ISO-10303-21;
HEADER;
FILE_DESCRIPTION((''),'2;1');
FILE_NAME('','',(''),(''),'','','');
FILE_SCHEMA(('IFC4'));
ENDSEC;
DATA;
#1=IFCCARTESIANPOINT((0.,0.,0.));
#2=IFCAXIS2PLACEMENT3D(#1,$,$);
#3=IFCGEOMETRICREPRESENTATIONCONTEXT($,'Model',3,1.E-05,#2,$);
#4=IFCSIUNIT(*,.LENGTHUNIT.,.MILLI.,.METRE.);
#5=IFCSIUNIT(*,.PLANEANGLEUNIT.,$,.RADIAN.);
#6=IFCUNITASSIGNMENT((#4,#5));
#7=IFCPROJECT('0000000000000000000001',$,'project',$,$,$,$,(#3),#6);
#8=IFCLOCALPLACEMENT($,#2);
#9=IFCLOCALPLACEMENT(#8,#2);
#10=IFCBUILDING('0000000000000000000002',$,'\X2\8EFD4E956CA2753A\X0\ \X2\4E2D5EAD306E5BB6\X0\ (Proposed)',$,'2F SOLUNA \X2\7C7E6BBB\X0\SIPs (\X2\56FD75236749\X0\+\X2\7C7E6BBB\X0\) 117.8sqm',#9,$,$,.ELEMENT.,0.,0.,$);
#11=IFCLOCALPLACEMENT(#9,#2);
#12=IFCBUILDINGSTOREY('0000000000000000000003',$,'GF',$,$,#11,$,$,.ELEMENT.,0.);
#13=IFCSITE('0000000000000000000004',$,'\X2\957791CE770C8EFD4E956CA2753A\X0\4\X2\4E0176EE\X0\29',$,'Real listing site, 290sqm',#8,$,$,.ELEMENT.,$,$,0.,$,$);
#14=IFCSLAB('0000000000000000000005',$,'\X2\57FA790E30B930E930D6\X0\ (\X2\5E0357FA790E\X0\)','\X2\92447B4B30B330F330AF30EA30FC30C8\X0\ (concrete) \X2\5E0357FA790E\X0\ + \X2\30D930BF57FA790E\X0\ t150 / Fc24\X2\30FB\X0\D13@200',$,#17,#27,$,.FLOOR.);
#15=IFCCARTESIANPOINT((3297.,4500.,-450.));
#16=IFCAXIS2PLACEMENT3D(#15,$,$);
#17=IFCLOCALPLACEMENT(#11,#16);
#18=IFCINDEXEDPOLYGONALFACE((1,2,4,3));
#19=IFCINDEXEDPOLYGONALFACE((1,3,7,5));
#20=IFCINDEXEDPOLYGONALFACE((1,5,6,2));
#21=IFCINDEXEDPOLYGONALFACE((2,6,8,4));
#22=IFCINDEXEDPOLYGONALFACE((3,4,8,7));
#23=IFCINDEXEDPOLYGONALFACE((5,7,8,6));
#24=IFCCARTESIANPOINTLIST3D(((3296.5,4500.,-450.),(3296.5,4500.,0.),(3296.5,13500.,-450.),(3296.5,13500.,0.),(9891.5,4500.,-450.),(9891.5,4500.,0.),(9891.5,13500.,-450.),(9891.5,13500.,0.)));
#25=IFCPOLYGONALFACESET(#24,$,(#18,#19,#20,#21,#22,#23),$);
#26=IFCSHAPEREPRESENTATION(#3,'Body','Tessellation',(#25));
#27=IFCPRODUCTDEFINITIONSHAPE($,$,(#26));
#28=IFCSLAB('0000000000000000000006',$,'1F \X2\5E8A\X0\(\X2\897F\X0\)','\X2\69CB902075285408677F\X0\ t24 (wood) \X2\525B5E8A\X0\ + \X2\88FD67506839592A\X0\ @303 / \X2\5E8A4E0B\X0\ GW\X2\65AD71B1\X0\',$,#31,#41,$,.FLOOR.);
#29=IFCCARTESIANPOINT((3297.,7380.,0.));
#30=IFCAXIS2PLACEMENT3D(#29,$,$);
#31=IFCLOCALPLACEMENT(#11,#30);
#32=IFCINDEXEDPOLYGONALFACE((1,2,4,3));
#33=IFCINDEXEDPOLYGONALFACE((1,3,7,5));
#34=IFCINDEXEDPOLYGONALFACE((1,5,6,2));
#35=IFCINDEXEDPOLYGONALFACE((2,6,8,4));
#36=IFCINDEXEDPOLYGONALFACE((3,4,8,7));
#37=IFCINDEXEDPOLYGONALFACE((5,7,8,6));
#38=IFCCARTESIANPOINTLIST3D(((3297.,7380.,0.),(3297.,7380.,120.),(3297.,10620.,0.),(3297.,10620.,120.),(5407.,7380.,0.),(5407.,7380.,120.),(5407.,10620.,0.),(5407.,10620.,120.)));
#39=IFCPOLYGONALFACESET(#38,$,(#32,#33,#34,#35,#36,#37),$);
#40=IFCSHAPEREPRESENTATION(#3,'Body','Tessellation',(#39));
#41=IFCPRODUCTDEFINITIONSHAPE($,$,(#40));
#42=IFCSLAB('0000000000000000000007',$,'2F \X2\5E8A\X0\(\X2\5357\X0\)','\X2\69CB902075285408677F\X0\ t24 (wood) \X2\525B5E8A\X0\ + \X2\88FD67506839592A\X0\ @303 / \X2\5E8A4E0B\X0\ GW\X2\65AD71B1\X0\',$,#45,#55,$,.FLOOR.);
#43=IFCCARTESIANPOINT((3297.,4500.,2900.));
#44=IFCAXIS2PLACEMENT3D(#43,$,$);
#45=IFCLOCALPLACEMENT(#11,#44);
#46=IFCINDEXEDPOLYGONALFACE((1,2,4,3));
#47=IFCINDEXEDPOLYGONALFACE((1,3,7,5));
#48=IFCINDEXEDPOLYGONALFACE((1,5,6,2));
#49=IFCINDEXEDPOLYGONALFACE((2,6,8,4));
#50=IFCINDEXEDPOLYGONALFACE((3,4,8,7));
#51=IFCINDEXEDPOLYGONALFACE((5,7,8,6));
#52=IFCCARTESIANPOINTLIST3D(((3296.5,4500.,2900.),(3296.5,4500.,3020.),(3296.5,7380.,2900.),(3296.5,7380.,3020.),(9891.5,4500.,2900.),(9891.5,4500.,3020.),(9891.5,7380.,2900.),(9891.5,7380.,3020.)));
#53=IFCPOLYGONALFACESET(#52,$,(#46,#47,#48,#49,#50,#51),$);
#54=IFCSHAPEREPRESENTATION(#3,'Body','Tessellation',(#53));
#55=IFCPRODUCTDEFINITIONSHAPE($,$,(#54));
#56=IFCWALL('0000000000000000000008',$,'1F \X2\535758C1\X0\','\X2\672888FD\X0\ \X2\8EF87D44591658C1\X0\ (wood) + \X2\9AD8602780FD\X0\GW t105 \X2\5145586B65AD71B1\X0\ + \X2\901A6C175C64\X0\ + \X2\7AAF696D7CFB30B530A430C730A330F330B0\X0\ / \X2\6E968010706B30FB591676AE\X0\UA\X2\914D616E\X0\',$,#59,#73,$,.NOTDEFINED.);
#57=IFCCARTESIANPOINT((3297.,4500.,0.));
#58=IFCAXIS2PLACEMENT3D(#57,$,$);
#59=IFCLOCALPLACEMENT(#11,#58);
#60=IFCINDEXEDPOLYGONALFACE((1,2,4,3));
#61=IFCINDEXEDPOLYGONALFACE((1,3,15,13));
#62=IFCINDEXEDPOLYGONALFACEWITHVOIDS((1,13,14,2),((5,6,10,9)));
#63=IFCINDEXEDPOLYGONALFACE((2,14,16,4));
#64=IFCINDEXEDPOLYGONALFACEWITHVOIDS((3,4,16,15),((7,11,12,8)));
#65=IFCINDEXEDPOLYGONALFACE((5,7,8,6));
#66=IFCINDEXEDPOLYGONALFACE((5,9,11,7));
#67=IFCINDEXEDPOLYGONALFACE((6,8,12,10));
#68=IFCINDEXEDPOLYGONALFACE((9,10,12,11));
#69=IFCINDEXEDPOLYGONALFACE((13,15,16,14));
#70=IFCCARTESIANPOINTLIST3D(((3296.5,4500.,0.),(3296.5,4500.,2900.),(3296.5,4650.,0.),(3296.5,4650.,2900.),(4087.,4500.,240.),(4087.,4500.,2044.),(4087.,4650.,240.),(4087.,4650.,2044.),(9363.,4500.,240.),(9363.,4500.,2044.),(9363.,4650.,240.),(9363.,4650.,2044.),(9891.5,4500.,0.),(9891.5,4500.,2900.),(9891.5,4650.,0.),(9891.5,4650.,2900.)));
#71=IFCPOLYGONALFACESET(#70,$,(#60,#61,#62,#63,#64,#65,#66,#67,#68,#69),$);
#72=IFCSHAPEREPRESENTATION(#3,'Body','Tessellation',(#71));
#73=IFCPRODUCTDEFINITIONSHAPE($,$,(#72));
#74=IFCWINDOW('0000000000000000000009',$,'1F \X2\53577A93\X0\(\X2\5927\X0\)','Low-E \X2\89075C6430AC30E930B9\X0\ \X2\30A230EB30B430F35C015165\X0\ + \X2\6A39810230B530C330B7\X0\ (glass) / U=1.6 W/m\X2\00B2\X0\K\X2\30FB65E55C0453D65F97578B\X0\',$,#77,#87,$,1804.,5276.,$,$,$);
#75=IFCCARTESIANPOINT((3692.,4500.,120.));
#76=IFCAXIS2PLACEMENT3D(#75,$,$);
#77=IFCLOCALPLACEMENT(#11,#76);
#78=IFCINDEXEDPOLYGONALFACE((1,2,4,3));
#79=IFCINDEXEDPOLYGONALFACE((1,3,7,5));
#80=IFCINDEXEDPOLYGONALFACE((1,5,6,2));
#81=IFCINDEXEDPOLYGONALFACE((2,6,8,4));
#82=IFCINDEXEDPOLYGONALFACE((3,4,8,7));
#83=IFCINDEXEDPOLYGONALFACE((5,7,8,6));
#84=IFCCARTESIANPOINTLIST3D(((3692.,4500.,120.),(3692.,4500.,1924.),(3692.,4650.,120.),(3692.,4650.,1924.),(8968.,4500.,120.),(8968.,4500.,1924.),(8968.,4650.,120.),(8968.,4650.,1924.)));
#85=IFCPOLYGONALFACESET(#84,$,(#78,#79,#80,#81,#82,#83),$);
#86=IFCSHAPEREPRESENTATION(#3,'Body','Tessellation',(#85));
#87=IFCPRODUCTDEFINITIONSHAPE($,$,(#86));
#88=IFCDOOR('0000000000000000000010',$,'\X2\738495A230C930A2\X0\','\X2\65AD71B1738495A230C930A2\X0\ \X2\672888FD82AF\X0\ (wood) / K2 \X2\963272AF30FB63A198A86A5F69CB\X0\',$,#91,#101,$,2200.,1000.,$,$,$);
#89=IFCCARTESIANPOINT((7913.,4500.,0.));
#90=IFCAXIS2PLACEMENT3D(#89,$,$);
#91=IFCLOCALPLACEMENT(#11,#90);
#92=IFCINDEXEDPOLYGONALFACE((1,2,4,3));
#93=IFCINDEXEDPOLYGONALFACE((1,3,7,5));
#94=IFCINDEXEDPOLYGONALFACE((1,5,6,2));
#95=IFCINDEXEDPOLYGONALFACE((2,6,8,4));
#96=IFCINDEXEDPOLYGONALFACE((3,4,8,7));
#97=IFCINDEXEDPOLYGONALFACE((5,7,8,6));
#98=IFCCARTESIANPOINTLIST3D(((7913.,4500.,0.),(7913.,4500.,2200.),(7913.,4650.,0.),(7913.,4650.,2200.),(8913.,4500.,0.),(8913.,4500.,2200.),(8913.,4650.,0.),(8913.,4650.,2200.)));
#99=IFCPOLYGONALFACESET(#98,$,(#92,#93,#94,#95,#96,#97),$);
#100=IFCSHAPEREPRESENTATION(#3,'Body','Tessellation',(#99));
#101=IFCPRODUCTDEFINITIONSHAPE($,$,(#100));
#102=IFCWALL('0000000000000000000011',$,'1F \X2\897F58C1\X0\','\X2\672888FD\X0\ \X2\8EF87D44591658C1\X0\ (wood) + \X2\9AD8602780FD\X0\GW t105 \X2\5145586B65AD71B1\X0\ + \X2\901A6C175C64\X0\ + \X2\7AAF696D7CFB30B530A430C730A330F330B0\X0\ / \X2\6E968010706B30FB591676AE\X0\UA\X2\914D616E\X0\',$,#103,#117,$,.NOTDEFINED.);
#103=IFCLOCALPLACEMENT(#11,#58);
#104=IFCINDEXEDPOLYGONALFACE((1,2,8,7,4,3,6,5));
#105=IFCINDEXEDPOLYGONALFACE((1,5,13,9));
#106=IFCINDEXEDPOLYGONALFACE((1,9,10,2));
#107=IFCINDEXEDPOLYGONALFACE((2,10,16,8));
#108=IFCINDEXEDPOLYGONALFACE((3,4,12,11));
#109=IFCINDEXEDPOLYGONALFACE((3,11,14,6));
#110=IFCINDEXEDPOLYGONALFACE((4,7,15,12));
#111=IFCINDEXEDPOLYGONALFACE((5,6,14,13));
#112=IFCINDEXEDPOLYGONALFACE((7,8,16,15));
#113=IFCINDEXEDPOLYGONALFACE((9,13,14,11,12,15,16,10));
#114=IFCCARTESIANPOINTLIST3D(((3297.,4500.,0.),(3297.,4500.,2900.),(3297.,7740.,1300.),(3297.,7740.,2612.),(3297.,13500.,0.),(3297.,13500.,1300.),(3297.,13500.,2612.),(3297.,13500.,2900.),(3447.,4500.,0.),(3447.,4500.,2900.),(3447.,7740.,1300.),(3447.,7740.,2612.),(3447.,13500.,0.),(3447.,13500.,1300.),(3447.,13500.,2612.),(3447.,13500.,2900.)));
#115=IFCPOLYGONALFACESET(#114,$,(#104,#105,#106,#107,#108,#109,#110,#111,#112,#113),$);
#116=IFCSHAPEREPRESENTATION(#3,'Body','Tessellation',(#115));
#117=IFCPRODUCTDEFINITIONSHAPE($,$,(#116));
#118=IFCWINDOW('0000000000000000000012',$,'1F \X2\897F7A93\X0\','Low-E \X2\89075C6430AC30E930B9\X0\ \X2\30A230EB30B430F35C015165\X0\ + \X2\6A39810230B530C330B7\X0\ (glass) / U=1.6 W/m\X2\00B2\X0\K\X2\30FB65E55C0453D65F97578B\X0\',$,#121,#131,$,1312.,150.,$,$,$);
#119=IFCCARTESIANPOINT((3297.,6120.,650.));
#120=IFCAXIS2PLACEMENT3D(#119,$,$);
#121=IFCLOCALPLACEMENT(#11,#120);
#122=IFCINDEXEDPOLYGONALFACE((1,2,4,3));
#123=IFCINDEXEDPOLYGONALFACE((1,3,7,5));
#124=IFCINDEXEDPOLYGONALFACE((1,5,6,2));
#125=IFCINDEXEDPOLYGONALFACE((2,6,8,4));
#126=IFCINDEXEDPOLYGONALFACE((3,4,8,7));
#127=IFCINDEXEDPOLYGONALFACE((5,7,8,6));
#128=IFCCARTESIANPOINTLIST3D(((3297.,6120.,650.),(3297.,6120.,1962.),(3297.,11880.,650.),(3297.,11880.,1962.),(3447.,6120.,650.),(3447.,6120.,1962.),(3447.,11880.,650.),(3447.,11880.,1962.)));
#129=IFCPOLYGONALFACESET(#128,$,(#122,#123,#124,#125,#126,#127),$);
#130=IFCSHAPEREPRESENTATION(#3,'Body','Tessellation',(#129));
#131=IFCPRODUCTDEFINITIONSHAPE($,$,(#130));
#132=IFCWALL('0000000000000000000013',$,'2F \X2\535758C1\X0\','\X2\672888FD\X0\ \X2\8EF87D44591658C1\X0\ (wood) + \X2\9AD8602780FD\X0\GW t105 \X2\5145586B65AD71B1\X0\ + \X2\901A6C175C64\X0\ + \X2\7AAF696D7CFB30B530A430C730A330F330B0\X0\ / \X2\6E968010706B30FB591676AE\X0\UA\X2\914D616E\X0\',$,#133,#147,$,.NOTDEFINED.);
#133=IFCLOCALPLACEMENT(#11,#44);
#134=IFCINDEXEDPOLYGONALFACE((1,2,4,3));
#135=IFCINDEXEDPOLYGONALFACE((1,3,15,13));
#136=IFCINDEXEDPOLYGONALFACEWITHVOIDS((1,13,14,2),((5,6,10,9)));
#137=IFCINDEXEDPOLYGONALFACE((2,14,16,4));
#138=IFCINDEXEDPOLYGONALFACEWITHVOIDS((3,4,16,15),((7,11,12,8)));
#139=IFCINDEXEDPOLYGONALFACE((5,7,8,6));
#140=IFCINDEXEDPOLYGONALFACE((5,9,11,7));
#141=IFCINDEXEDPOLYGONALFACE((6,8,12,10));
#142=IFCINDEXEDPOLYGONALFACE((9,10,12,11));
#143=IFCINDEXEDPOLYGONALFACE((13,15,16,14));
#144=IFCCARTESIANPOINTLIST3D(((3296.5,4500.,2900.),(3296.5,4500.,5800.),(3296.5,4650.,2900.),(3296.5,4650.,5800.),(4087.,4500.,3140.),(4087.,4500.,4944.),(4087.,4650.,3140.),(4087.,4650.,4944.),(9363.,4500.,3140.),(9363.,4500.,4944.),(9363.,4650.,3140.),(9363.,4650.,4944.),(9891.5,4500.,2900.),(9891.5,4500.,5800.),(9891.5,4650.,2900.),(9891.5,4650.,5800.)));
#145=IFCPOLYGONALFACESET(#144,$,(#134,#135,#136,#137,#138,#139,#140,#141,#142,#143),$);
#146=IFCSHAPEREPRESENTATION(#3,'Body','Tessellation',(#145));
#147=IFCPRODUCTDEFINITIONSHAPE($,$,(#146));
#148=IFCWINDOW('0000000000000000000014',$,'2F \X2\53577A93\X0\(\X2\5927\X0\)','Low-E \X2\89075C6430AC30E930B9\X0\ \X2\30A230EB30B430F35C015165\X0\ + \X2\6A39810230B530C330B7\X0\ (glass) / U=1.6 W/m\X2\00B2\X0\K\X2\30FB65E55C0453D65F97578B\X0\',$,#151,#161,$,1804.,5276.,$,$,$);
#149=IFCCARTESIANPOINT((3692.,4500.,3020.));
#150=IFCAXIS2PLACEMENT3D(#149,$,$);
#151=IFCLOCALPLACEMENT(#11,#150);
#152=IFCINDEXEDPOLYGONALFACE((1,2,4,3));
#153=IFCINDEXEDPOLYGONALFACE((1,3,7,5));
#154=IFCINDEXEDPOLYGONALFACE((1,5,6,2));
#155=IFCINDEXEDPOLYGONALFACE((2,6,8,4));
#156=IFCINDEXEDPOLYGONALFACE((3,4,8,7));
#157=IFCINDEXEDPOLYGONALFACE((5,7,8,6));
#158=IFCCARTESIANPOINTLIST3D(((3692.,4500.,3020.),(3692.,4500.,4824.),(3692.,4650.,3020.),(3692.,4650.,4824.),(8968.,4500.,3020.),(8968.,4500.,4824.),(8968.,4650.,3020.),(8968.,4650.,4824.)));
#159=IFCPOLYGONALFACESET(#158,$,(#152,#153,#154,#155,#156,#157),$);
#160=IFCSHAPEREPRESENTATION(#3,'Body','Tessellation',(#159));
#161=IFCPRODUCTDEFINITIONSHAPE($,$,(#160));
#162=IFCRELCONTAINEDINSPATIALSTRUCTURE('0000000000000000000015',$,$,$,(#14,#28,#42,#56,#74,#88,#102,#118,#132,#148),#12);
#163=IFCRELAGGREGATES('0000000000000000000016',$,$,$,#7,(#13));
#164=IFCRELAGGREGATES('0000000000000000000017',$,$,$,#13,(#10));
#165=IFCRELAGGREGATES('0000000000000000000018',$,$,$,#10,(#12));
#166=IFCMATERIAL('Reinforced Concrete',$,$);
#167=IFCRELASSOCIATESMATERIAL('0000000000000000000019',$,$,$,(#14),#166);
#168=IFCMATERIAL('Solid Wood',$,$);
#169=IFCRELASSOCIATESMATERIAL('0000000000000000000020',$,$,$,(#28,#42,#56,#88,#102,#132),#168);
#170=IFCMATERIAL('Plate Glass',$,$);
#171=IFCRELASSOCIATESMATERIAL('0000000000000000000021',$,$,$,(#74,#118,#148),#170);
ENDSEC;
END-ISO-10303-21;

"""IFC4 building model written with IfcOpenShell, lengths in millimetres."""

from ifc_helpers import new_model, si_unit, frame, frame_2d, origin, place, context, project, spatial, rectangle, extrude, material, element, fill, save


model = new_model("IFC4")

# Units and contexts
model_context = context("Model", 3, precision=1e-05, world=origin())
ifc_project = project(units=[si_unit("LENGTHUNIT", "METRE", prefix="MILLI"), si_unit("PLANEANGLEUNIT", "RADIAN")], contexts=[model_context])

# Site, building, storey
site_placement = place(None, origin())
site = spatial("IfcSite", under=ifc_project, at=site_placement, Name="長野県軽井沢町4丁目29", ObjectType="Real listing site, 290sqm", CompositionType="ELEMENT", RefElevation=0.0)
building_placement = place(site_placement, origin())
building = spatial("IfcBuilding", under=site, at=building_placement, Name="軽井沢町 中庭の家 (Proposed)", ObjectType="2F SOLUNA 籾殻SIPs (国産杉+籾殻) 117.8sqm", CompositionType="ELEMENT", ElevationOfRefHeight=0.0, ElevationOfTerrain=0.0)
storey_placement = place(building_placement, origin())
storey = spatial("IfcBuildingStorey", under=building, at=storey_placement, Name="GF", CompositionType="ELEMENT", Elevation=0.0)

# Slabs
ifc_material_1 = material(Name="Reinforced Concrete")
slab_1_placement = place(storey_placement, frame((3297.0, 4500.0, -450.0)))
element("IfcSlab", 1, at=slab_1_placement, inside=storey, material=ifc_material_1, Name="基礎スラブ (布基礎)", Description="鉄筋コンクリート (concrete) 布基礎 + ベタ基礎 t150 / Fc24・D13@200", PredefinedType="FLOOR", context=model_context, shape_type="SweptSolid", body=[
    extrude(rectangle(XDim=6595.0, YDim=9000.0, at=frame_2d((3297.0, 4500.0))), frame((3297.0, 4500.0, -450.0)), (0.0, 0.0, 1.0), 450.0),
])
ifc_material_2 = material(Name="Solid Wood")
slab_2_placement = place(storey_placement, frame((3297.0, 7380.0, 0.0)))
element("IfcSlab", 2, at=slab_2_placement, inside=storey, material=ifc_material_2, Name="1F 床(西)", Description="構造用合板 t24 (wood) 剛床 + 製材根太 @303 / 床下 GW断熱", PredefinedType="FLOOR", context=model_context, shape_type="SweptSolid", body=[
    extrude(rectangle(XDim=2110.0, YDim=3240.0, at=frame_2d((1055.0, 1620.0))), frame((3297.0, 7380.0, 0.0)), (0.0, 0.0, 1.0), 120.0),
])
slab_3_placement = place(storey_placement, frame((3297.0, 4500.0, 2900.0)))
element("IfcSlab", 3, at=slab_3_placement, inside=storey, material=ifc_material_2, Name="2F 床(南)", Description="構造用合板 t24 (wood) 剛床 + 製材根太 @303 / 床下 GW断熱", PredefinedType="FLOOR", context=model_context, shape_type="SweptSolid", body=[
    extrude(rectangle(XDim=6595.0, YDim=2880.0, at=frame_2d((3297.0, 1440.0))), frame((3297.0, 4500.0, 2900.0)), (0.0, 0.0, 1.0), 120.0),
])

# Wall, openings, window, door
wall_1_placement = place(storey_placement, frame((3297.0, 4500.0, 0.0)))
wall_1 = element("IfcWall", 4, at=wall_1_placement, inside=storey, material=ifc_material_2, Name="1F 南壁", Description="木製 軸組外壁 (wood) + 高性能GW t105 充填断熱 + 通気層 + 窯業系サイディング / 準耐火・外皮UA配慮", PredefinedType="NOTDEFINED", context=model_context, shape_type="SweptSolid", body=[
    extrude(rectangle(XDim=6595.0, YDim=150.0, at=frame_2d((3297.0, 75.0))), frame((3297.0, 4500.0, 0.0)), (0.0, 0.0, 1.0), 2900.0),
])
opening_1_placement = place(storey_placement, frame((3692.0, 4500.0, 120.0)))
opening_1 = element("IfcOpeningElement", 5, at=opening_1_placement, cuts=wall_1, PredefinedType="NOTDEFINED", context=model_context, shape_type="SweptSolid", body=[
    extrude(rectangle(XDim=5276.0, YDim=150.0, at=frame_2d((2638.0, 75.0))), frame((3692.0, 4500.0, 120.0)), (0.0, 0.0, 1.0), 1804.0),
])
opening_2_placement = place(storey_placement, frame((7913.0, 4500.0, 0.0)))
opening_2 = element("IfcOpeningElement", 6, at=opening_2_placement, cuts=wall_1, PredefinedType="NOTDEFINED", context=model_context, shape_type="SweptSolid", body=[
    extrude(rectangle(XDim=1000.0, YDim=150.0, at=frame_2d((500.0, 75.0))), frame((7913.0, 4500.0, 0.0)), (0.0, 0.0, 1.0), 2200.0),
])
ifc_material_3 = material(Name="Plate Glass")
window_1_placement = place(storey_placement, frame((3692.0, 4500.0, 120.0)))
window_1 = element("IfcWindow", 7, at=window_1_placement, inside=storey, material=ifc_material_3, Name="1F 南窓(大)", Description="Low-E 複層ガラス アルゴン封入 + 樹脂サッシ (glass) / U=1.6 W/m²K・日射取得型", OverallHeight=1804.0, OverallWidth=5276.0, context=model_context, shape_type="SweptSolid", body=[
    extrude(rectangle(XDim=5276.0, YDim=150.0, at=frame_2d((2638.0, 75.0))), frame((3692.0, 4500.0, 120.0)), (0.0, 0.0, 1.0), 1804.0),
])
fill(opening_1, window_1)
door_placement = place(storey_placement, frame((7913.0, 4500.0, 0.0)))
door = element("IfcDoor", 8, at=door_placement, inside=storey, material=ifc_material_2, Name="玄関ドア", Description="断熱玄関ドア 木製芯 (wood) / K2 防犯・採風機構", OverallHeight=2200.0, OverallWidth=1000.0, context=model_context, shape_type="SweptSolid", body=[
    extrude(rectangle(XDim=1000.0, YDim=150.0, at=frame_2d((500.0, 75.0))), frame((7913.0, 4500.0, 0.0)), (0.0, 0.0, 1.0), 2200.0),
])
fill(opening_2, door)

# Walls, openings, windows
wall_2_placement = place(storey_placement, frame((3297.0, 4500.0, 0.0)))
wall_2 = element("IfcWall", 9, at=wall_2_placement, inside=storey, material=ifc_material_2, Name="1F 西壁", Description="木製 軸組外壁 (wood) + 高性能GW t105 充填断熱 + 通気層 + 窯業系サイディング / 準耐火・外皮UA配慮", PredefinedType="NOTDEFINED", context=model_context, shape_type="SweptSolid", body=[
    extrude(rectangle(XDim=150.0, YDim=9000.0, at=frame_2d((75.0, 4500.0))), frame((3297.0, 4500.0, 0.0)), (0.0, 0.0, 1.0), 2900.0),
])
opening_3_placement = place(storey_placement, frame((3297.0, 6120.0, 650.0)))
opening_3 = element("IfcOpeningElement", 10, at=opening_3_placement, cuts=wall_2, PredefinedType="NOTDEFINED", context=model_context, shape_type="SweptSolid", body=[
    extrude(rectangle(XDim=150.0, YDim=5760.0, at=frame_2d((75.0, 2880.0))), frame((3297.0, 6120.0, 650.0)), (0.0, 0.0, 1.0), 1312.0),
])
window_2_placement = place(storey_placement, frame((3297.0, 6120.0, 650.0)))
window_2 = element("IfcWindow", 11, at=window_2_placement, inside=storey, material=ifc_material_3, Name="1F 西窓", Description="Low-E 複層ガラス アルゴン封入 + 樹脂サッシ (glass) / U=1.6 W/m²K・日射取得型", OverallHeight=1312.0, OverallWidth=150.0, context=model_context, shape_type="SweptSolid", body=[
    extrude(rectangle(XDim=150.0, YDim=5760.0, at=frame_2d((75.0, 2880.0))), frame((3297.0, 6120.0, 650.0)), (0.0, 0.0, 1.0), 1312.0),
])
fill(opening_3, window_2)
wall_3_placement = place(storey_placement, frame((3297.0, 4500.0, 2900.0)))
wall_3 = element("IfcWall", 12, at=wall_3_placement, inside=storey, material=ifc_material_2, Name="2F 南壁", Description="木製 軸組外壁 (wood) + 高性能GW t105 充填断熱 + 通気層 + 窯業系サイディング / 準耐火・外皮UA配慮", PredefinedType="NOTDEFINED", context=model_context, shape_type="SweptSolid", body=[
    extrude(rectangle(XDim=6595.0, YDim=150.0, at=frame_2d((3297.0, 75.0))), frame((3297.0, 4500.0, 2900.0)), (0.0, 0.0, 1.0), 2900.0),
])
opening_4_placement = place(storey_placement, frame((3692.0, 4500.0, 3020.0)))
opening_4 = element("IfcOpeningElement", 13, at=opening_4_placement, cuts=wall_3, PredefinedType="NOTDEFINED", context=model_context, shape_type="SweptSolid", body=[
    extrude(rectangle(XDim=5276.0, YDim=150.0, at=frame_2d((2638.0, 75.0))), frame((3692.0, 4500.0, 3020.0)), (0.0, 0.0, 1.0), 1804.0),
])
window_3_placement = place(storey_placement, frame((3692.0, 4500.0, 3020.0)))
window_3 = element("IfcWindow", 14, at=window_3_placement, inside=storey, material=ifc_material_3, Name="2F 南窓(大)", Description="Low-E 複層ガラス アルゴン封入 + 樹脂サッシ (glass) / U=1.6 W/m²K・日射取得型", OverallHeight=1804.0, OverallWidth=5276.0, context=model_context, shape_type="SweptSolid", body=[
    extrude(rectangle(XDim=5276.0, YDim=150.0, at=frame_2d((2638.0, 75.0))), frame((3692.0, 4500.0, 3020.0)), (0.0, 0.0, 1.0), 1804.0),
])
fill(opening_4, window_3)

save(model, "model.ifc")
